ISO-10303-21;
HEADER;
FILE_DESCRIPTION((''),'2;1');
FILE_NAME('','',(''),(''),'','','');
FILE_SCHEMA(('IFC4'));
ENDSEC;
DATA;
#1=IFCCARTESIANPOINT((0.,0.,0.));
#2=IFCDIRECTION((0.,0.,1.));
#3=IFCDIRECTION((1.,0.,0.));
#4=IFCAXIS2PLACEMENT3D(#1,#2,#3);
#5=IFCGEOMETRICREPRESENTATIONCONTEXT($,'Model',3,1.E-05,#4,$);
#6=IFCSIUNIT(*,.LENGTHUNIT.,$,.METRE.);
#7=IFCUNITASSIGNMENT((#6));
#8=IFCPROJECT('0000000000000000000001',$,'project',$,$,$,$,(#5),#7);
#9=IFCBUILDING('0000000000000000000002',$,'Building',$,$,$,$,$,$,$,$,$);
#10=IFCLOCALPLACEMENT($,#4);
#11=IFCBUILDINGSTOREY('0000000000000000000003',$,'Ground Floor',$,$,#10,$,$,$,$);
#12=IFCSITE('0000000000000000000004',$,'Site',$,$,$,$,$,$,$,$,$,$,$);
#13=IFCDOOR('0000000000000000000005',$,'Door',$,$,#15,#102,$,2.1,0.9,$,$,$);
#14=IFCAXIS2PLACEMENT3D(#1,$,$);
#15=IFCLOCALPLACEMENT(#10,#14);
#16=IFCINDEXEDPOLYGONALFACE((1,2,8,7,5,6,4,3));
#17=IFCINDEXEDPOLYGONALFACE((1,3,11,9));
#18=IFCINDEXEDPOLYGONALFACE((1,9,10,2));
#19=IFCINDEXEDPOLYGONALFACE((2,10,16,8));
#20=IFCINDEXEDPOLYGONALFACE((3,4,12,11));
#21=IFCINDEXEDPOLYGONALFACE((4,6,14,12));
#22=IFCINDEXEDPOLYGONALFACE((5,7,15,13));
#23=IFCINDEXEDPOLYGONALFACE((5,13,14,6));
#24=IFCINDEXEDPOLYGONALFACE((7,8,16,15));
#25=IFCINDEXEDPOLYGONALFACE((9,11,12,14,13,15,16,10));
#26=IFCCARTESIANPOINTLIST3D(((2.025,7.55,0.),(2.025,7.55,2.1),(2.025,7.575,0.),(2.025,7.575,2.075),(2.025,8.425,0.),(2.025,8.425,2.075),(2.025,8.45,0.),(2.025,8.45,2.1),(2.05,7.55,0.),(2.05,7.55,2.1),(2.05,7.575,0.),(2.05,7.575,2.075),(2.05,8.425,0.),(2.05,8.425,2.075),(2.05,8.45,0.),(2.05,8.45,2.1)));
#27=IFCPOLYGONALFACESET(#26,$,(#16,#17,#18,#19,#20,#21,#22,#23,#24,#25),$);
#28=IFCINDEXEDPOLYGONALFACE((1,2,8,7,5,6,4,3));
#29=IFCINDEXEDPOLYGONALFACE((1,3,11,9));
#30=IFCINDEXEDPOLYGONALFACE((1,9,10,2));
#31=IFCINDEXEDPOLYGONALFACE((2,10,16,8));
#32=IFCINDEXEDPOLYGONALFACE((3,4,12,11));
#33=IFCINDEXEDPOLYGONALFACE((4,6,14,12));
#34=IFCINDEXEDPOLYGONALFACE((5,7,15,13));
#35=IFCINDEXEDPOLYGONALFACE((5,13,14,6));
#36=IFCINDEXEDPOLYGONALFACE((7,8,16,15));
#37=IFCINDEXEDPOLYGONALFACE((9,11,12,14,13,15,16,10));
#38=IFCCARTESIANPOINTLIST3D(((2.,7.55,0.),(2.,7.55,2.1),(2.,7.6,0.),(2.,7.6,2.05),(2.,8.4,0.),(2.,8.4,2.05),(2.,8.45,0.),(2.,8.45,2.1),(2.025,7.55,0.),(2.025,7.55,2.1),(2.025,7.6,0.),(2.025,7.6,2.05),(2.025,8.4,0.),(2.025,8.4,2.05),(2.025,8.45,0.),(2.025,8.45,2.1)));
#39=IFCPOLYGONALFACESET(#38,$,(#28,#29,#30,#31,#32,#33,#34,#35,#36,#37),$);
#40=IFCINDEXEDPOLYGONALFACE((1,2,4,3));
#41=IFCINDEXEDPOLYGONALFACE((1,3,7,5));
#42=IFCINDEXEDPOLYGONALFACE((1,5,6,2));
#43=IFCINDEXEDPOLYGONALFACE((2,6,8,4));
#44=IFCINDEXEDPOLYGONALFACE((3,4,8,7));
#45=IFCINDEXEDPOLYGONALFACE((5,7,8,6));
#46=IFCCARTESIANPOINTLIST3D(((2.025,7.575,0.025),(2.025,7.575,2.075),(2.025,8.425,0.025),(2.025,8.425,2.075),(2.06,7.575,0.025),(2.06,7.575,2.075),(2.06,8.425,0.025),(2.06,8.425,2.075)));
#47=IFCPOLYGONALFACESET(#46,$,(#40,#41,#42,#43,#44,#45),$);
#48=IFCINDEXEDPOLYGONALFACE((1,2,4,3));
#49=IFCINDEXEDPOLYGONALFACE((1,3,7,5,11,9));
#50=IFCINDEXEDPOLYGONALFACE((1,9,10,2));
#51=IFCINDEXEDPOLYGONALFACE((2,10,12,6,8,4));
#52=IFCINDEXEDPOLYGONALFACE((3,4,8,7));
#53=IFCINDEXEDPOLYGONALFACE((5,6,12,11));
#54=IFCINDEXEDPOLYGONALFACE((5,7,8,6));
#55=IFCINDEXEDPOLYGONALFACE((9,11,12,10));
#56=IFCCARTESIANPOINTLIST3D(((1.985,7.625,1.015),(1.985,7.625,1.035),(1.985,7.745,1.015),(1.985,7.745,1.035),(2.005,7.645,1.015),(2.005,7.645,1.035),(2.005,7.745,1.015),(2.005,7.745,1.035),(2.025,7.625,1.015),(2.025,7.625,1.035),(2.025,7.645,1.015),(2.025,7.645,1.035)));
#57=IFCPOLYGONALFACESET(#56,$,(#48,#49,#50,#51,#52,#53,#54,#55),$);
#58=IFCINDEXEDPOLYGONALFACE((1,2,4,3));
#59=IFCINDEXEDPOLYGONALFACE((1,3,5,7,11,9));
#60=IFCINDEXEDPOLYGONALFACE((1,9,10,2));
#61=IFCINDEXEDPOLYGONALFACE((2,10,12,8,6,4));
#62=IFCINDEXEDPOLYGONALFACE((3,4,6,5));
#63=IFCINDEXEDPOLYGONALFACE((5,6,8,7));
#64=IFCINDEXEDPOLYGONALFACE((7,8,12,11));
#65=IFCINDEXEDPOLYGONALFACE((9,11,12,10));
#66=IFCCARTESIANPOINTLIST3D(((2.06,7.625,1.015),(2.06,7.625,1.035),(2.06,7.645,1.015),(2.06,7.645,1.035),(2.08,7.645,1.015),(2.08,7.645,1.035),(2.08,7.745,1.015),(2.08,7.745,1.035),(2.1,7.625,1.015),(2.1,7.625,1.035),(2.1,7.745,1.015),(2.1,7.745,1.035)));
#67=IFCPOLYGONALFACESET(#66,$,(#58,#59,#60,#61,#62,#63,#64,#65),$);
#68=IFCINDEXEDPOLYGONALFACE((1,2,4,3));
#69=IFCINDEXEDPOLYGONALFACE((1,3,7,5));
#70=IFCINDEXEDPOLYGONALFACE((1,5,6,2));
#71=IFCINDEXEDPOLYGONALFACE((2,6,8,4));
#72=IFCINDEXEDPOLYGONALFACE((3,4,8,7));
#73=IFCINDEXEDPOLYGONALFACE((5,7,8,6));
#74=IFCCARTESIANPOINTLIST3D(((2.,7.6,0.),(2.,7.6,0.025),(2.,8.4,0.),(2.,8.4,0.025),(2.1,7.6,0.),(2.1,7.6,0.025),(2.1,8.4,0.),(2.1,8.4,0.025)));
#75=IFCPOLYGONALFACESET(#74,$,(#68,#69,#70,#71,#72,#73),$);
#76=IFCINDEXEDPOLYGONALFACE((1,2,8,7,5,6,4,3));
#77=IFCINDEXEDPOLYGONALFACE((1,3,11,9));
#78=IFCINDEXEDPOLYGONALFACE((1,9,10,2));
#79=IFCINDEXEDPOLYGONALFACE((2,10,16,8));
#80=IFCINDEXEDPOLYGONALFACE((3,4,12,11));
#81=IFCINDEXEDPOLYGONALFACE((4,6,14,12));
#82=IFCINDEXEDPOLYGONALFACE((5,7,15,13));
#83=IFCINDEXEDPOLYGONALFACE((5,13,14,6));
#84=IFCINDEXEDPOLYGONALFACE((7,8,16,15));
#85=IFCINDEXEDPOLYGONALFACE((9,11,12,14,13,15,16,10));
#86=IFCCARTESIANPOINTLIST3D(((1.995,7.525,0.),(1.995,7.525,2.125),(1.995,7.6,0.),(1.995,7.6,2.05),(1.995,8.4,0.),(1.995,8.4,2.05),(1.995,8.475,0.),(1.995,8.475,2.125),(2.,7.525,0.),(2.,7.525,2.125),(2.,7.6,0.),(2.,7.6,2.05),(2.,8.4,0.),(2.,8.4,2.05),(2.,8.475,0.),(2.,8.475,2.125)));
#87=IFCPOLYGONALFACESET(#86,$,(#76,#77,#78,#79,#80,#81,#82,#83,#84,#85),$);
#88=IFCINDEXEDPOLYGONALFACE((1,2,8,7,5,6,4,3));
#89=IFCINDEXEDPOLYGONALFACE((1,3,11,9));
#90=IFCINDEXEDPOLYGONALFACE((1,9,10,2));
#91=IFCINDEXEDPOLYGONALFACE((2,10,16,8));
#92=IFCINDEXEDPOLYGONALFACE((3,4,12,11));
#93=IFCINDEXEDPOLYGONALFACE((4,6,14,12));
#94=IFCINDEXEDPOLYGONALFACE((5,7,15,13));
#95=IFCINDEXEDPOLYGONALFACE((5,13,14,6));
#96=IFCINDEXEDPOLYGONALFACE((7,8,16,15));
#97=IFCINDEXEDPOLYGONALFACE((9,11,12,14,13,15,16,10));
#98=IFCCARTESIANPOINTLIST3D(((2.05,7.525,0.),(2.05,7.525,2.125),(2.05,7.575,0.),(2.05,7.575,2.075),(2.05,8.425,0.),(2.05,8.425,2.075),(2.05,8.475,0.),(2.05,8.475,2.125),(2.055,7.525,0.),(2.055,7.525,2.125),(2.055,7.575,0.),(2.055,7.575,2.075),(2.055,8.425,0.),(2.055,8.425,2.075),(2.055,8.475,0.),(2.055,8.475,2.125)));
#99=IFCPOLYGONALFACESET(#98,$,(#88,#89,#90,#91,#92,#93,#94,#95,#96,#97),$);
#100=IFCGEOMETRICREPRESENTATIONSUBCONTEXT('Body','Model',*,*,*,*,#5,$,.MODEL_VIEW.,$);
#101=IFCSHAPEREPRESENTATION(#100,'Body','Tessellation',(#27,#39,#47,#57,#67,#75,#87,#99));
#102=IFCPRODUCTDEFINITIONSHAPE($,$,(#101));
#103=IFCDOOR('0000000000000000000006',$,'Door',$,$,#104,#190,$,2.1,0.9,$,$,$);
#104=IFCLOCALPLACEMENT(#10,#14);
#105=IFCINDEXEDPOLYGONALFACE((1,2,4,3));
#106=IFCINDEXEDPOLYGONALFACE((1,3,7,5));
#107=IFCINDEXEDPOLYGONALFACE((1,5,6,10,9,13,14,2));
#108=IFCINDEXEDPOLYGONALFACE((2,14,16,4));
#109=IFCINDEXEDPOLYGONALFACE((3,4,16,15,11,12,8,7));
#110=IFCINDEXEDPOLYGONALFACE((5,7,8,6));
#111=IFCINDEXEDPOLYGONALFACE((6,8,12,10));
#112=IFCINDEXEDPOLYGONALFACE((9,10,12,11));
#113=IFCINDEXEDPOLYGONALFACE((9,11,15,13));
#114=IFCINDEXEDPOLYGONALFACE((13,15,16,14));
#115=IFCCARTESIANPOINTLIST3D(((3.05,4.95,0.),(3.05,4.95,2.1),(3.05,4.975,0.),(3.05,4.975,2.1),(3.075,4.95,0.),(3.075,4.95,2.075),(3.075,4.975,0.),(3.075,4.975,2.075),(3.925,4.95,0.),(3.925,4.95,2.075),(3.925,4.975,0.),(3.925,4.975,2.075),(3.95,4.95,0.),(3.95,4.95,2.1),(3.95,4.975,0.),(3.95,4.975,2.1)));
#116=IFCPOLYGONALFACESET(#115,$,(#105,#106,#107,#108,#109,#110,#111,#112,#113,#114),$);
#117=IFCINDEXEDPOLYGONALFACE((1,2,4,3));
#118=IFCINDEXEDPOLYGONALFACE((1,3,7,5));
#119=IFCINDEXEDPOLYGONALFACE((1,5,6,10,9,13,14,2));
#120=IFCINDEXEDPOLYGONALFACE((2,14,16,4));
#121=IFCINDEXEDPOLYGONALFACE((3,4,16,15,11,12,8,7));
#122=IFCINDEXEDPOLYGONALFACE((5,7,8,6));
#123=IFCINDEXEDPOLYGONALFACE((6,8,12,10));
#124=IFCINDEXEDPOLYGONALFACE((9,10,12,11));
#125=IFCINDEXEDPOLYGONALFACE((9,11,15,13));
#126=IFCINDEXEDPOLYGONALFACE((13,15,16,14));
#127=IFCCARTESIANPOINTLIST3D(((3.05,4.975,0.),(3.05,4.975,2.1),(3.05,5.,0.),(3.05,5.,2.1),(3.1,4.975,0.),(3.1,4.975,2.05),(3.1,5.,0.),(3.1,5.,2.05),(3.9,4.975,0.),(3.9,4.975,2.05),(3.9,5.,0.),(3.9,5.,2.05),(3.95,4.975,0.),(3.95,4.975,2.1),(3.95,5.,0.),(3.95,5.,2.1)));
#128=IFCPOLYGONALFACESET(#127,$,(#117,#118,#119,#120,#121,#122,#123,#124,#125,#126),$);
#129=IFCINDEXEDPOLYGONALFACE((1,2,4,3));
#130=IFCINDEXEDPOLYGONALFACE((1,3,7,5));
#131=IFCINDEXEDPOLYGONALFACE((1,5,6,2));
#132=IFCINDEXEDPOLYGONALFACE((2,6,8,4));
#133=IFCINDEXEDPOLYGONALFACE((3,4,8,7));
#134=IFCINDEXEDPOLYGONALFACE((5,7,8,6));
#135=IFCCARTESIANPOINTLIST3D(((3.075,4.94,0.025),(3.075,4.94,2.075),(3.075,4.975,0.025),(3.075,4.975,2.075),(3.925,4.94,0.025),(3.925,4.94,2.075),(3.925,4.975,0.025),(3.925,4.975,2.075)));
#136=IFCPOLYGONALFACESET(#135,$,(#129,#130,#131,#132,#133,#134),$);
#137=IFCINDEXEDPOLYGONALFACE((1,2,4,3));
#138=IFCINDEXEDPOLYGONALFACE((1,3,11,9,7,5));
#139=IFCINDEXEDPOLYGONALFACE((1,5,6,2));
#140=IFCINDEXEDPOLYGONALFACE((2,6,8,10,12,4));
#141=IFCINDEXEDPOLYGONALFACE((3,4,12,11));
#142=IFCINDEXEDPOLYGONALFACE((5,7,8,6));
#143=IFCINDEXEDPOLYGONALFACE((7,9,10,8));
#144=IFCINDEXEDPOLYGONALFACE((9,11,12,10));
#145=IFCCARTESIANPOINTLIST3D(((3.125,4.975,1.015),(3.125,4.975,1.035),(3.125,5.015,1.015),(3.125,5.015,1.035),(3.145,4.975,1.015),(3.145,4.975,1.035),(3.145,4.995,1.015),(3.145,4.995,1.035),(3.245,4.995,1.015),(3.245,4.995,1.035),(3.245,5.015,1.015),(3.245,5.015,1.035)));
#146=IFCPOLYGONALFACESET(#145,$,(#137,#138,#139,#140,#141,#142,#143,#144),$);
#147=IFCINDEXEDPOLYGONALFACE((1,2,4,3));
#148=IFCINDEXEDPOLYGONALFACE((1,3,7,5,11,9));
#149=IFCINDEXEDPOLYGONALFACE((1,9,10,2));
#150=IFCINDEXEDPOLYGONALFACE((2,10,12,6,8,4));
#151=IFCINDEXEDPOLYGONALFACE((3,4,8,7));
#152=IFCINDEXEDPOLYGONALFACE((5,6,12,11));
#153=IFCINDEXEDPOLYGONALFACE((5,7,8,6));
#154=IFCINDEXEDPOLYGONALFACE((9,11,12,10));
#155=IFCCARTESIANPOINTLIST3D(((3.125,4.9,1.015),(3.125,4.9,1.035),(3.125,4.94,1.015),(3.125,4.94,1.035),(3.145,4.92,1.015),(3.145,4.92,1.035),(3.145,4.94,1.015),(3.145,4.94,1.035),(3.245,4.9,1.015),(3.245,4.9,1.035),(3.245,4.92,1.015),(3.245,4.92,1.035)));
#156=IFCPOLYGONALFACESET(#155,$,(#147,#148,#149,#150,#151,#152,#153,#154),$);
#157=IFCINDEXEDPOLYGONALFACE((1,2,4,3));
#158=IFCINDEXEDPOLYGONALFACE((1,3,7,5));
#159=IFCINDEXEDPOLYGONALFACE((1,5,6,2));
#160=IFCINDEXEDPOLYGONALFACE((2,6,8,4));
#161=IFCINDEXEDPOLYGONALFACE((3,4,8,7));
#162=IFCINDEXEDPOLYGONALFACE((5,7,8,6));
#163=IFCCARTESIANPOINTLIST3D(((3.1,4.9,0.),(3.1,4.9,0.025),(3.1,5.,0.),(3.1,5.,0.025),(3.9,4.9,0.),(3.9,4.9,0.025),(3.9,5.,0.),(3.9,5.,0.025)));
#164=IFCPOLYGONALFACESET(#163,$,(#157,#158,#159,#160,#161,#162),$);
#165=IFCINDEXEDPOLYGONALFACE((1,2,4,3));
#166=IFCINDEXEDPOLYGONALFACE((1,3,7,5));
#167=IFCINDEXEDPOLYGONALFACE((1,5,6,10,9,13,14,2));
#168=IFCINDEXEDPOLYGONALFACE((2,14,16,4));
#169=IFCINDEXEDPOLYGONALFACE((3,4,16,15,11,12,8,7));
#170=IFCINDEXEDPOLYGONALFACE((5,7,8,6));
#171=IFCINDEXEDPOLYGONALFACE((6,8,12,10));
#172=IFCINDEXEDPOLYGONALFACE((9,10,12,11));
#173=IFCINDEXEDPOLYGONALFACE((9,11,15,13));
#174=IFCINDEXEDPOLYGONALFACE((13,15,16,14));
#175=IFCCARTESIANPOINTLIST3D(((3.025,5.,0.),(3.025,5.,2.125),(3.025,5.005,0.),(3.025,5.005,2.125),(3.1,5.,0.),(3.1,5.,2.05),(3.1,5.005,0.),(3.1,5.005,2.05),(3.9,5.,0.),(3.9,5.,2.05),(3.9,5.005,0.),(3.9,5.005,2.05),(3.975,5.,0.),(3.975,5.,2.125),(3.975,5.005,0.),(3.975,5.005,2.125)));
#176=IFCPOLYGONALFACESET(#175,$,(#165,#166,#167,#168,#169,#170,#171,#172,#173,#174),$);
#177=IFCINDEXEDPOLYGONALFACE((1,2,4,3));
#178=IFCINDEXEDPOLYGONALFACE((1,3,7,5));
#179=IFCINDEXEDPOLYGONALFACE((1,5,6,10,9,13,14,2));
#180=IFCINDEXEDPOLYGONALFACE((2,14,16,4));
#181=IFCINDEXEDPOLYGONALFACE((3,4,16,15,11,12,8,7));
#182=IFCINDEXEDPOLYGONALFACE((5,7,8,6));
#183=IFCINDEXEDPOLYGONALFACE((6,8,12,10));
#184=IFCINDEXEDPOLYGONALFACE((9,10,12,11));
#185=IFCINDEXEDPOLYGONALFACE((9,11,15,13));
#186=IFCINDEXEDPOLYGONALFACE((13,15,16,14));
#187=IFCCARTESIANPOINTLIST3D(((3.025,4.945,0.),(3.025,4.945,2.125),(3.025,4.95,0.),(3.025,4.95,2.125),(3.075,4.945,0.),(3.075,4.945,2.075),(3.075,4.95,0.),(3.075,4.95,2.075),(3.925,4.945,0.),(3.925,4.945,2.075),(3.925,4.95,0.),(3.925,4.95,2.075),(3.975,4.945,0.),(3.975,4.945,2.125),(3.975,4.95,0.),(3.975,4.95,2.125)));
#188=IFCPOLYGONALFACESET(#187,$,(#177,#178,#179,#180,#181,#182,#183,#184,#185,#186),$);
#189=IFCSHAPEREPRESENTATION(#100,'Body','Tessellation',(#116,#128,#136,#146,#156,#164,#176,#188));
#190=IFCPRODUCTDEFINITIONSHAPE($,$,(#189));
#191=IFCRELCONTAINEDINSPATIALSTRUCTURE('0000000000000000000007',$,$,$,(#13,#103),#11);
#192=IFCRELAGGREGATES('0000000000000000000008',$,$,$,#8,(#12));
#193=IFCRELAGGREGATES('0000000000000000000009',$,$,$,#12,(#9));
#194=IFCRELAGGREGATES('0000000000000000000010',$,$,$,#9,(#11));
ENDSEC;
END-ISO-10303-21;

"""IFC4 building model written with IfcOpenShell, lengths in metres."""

from ifc_helpers import new_model, si_unit, frame, origin_with_axes, place, context, subcontext, project, spatial, line, indexed_curve, outline, extrude, element, save


model = new_model("IFC4")

# Units and contexts
model_context = context("Model", 3, precision=1e-05, world=origin_with_axes())
body_context = subcontext(model_context, "Body", "Model", "MODEL_VIEW")
ifc_project = project(units=[si_unit("LENGTHUNIT", "METRE")], contexts=[model_context])

# Site, building, storey
site = spatial("IfcSite", under=ifc_project, Name="Site")
building = spatial("IfcBuilding", under=site, Name="Building")
storey_placement = place(None, origin_with_axes())
storey = spatial("IfcBuildingStorey", under=building, at=storey_placement, Name="Ground Floor")

# Doors
door_1_placement = place(storey_placement, frame((2.0, 8.45, 0.0), z_axis=(0.0, 0.0, 1.0), x_axis=(0.0, -1.0, 0.0)))
element("IfcDoor", 1, at=door_1_placement, inside=storey, Name="Door", OverallHeight=2.1, OverallWidth=0.9, context=body_context, shape_type="SweptSolid", body=[
    extrude(outline(indexed_curve([(0.0, 0.0), (0.0, 2.1), (0.9, 2.1), (0.9, 0.0), (0.875, 0.0), (0.875, 2.075), (0.025, 2.075), (0.025, 0.0)], segments=[line(1, 2, 3, 4, 5, 6, 7, 8, 1)])), frame((0.0, 0.025, 0.0), z_axis=(0.0, -1.0, 0.0), x_axis=(1.0, 0.0, 0.0)), (0.0, 0.0, -1.0), 0.025),
    extrude(outline(indexed_curve([(0.0, 0.0), (0.0, 2.1), (0.9, 2.1), (0.9, 0.0), (0.85, 0.0), (0.85, 2.05), (0.05, 2.05), (0.05, 0.0)], segments=[line(1, 2, 3, 4, 5, 6, 7, 8, 1)])), frame((0.0, 0.0, 0.0), z_axis=(0.0, -1.0, 0.0), x_axis=(1.0, 0.0, 0.0)), (0.0, 0.0, -1.0), 0.025),
    extrude(outline(indexed_curve([(0.0, 0.0), (0.85, 0.0), (0.85, 0.035), (0.0, 0.035)], segments=[line(1, 2, 3, 4, 1)])), frame((0.025, 0.025, 0.025), z_axis=(0.0, 0.0, 1.0), x_axis=(1.0, 0.0, 0.0)), (0.0, 0.0, 1.0), 2.05),
    extrude(outline(indexed_curve([(0.0, 0.0), (0.0, -0.04), (-0.12, -0.04), (-0.12, -0.02), (-0.02, -0.02), (-0.02, 0.0)], segments=[line(1, 2, 3, 4, 5, 6, 1)])), frame((0.825, 0.025, 1.015), z_axis=(0.0, 0.0, 1.0), x_axis=(1.0, 0.0, 0.0)), (0.0, 0.0, 1.0), 0.02),
    extrude(outline(indexed_curve([(0.0, 0.0), (0.0, 0.04), (-0.12, 0.04), (-0.12, 0.02), (-0.02, 0.02), (-0.02, 0.0)], segments=[line(1, 2, 3, 4, 5, 6, 1)])), frame((0.825, 0.06, 1.015), z_axis=(0.0, 0.0, 1.0), x_axis=(1.0, 0.0, 0.0)), (0.0, 0.0, 1.0), 0.02),
    extrude(outline(indexed_curve([(0.0, 0.0), (0.8, 0.0), (0.8, 0.1), (0.0, 0.1)], segments=[line(1, 2, 3, 4, 1)])), frame((0.05, 0.0, 0.0), z_axis=(0.0, 0.0, 1.0), x_axis=(1.0, 0.0, 0.0)), (0.0, 0.0, 1.0), 0.025),
    extrude(outline(indexed_curve([(0.0, 0.0), (0.0, 2.125), (0.95, 2.125), (0.95, 0.0), (0.875, 0.0), (0.875, 2.05), (0.075, 2.05), (0.075, 0.0)], segments=[line(1, 2, 3, 4, 5, 6, 7, 8, 1)])), frame((-0.025, -0.005, 0.0), z_axis=(0.0, -1.0, 0.0), x_axis=(1.0, 0.0, 0.0)), (0.0, 0.0, -1.0), 0.005),
    extrude(outline(indexed_curve([(0.0, 0.0), (0.0, 2.125), (0.95, 2.125), (0.95, 0.0), (0.9, 0.0), (0.9, 2.075), (0.05, 2.075), (0.05, 0.0)], segments=[line(1, 2, 3, 4, 5, 6, 7, 8, 1)])), frame((-0.025, 0.05, 0.0), z_axis=(0.0, -1.0, 0.0), x_axis=(1.0, 0.0, 0.0)), (0.0, 0.0, -1.0), 0.005),
])
door_2_placement = place(storey_placement, frame((3.95, 5.0, 0.0), z_axis=(0.0, 0.0, 1.0), x_axis=(-1.0, 0.0, 0.0)))
element("IfcDoor", 2, at=door_2_placement, inside=storey, Name="Door", OverallHeight=2.1, OverallWidth=0.9, context=body_context, shape_type="SweptSolid", body=[
    extrude(outline(indexed_curve([(0.0, 0.0), (0.0, 2.1), (0.9, 2.1), (0.9, 0.0), (0.875, 0.0), (0.875, 2.075), (0.025, 2.075), (0.025, 0.0)], segments=[line(1, 2, 3, 4, 5, 6, 7, 8, 1)])), frame((0.0, 0.025, 0.0), z_axis=(0.0, -1.0, 0.0), x_axis=(1.0, 0.0, 0.0)), (0.0, 0.0, -1.0), 0.025),
    extrude(outline(indexed_curve([(0.0, 0.0), (0.0, 2.1), (0.9, 2.1), (0.9, 0.0), (0.85, 0.0), (0.85, 2.05), (0.05, 2.05), (0.05, 0.0)], segments=[line(1, 2, 3, 4, 5, 6, 7, 8, 1)])), frame((0.0, 0.0, 0.0), z_axis=(0.0, -1.0, 0.0), x_axis=(1.0, 0.0, 0.0)), (0.0, 0.0, -1.0), 0.025),
    extrude(outline(indexed_curve([(0.0, 0.0), (0.85, 0.0), (0.85, 0.035), (0.0, 0.035)], segments=[line(1, 2, 3, 4, 1)])), frame((0.025, 0.025, 0.025), z_axis=(0.0, 0.0, 1.0), x_axis=(1.0, 0.0, 0.0)), (0.0, 0.0, 1.0), 2.05),
    extrude(outline(indexed_curve([(0.0, 0.0), (0.0, -0.04), (-0.12, -0.04), (-0.12, -0.02), (-0.02, -0.02), (-0.02, 0.0)], segments=[line(1, 2, 3, 4, 5, 6, 1)])), frame((0.825, 0.025, 1.015), z_axis=(0.0, 0.0, 1.0), x_axis=(1.0, 0.0, 0.0)), (0.0, 0.0, 1.0), 0.02),
    extrude(outline(indexed_curve([(0.0, 0.0), (0.0, 0.04), (-0.12, 0.04), (-0.12, 0.02), (-0.02, 0.02), (-0.02, 0.0)], segments=[line(1, 2, 3, 4, 5, 6, 1)])), frame((0.825, 0.06, 1.015), z_axis=(0.0, 0.0, 1.0), x_axis=(1.0, 0.0, 0.0)), (0.0, 0.0, 1.0), 0.02),
    extrude(outline(indexed_curve([(0.0, 0.0), (0.8, 0.0), (0.8, 0.1), (0.0, 0.1)], segments=[line(1, 2, 3, 4, 1)])), frame((0.05, 0.0, 0.0), z_axis=(0.0, 0.0, 1.0), x_axis=(1.0, 0.0, 0.0)), (0.0, 0.0, 1.0), 0.025),
    extrude(outline(indexed_curve([(0.0, 0.0), (0.0, 2.125), (0.95, 2.125), (0.95, 0.0), (0.875, 0.0), (0.875, 2.05), (0.075, 2.05), (0.075, 0.0)], segments=[line(1, 2, 3, 4, 5, 6, 7, 8, 1)])), frame((-0.025, -0.005, 0.0), z_axis=(0.0, -1.0, 0.0), x_axis=(1.0, 0.0, 0.0)), (0.0, 0.0, -1.0), 0.005),
    extrude(outline(indexed_curve([(0.0, 0.0), (0.0, 2.125), (0.95, 2.125), (0.95, 0.0), (0.9, 0.0), (0.9, 2.075), (0.05, 2.075), (0.05, 0.0)], segments=[line(1, 2, 3, 4, 5, 6, 7, 8, 1)])), frame((-0.025, 0.05, 0.0), z_axis=(0.0, -1.0, 0.0), x_axis=(1.0, 0.0, 0.0)), (0.0, 0.0, -1.0), 0.005),
])

save(model, "model.ifc")
